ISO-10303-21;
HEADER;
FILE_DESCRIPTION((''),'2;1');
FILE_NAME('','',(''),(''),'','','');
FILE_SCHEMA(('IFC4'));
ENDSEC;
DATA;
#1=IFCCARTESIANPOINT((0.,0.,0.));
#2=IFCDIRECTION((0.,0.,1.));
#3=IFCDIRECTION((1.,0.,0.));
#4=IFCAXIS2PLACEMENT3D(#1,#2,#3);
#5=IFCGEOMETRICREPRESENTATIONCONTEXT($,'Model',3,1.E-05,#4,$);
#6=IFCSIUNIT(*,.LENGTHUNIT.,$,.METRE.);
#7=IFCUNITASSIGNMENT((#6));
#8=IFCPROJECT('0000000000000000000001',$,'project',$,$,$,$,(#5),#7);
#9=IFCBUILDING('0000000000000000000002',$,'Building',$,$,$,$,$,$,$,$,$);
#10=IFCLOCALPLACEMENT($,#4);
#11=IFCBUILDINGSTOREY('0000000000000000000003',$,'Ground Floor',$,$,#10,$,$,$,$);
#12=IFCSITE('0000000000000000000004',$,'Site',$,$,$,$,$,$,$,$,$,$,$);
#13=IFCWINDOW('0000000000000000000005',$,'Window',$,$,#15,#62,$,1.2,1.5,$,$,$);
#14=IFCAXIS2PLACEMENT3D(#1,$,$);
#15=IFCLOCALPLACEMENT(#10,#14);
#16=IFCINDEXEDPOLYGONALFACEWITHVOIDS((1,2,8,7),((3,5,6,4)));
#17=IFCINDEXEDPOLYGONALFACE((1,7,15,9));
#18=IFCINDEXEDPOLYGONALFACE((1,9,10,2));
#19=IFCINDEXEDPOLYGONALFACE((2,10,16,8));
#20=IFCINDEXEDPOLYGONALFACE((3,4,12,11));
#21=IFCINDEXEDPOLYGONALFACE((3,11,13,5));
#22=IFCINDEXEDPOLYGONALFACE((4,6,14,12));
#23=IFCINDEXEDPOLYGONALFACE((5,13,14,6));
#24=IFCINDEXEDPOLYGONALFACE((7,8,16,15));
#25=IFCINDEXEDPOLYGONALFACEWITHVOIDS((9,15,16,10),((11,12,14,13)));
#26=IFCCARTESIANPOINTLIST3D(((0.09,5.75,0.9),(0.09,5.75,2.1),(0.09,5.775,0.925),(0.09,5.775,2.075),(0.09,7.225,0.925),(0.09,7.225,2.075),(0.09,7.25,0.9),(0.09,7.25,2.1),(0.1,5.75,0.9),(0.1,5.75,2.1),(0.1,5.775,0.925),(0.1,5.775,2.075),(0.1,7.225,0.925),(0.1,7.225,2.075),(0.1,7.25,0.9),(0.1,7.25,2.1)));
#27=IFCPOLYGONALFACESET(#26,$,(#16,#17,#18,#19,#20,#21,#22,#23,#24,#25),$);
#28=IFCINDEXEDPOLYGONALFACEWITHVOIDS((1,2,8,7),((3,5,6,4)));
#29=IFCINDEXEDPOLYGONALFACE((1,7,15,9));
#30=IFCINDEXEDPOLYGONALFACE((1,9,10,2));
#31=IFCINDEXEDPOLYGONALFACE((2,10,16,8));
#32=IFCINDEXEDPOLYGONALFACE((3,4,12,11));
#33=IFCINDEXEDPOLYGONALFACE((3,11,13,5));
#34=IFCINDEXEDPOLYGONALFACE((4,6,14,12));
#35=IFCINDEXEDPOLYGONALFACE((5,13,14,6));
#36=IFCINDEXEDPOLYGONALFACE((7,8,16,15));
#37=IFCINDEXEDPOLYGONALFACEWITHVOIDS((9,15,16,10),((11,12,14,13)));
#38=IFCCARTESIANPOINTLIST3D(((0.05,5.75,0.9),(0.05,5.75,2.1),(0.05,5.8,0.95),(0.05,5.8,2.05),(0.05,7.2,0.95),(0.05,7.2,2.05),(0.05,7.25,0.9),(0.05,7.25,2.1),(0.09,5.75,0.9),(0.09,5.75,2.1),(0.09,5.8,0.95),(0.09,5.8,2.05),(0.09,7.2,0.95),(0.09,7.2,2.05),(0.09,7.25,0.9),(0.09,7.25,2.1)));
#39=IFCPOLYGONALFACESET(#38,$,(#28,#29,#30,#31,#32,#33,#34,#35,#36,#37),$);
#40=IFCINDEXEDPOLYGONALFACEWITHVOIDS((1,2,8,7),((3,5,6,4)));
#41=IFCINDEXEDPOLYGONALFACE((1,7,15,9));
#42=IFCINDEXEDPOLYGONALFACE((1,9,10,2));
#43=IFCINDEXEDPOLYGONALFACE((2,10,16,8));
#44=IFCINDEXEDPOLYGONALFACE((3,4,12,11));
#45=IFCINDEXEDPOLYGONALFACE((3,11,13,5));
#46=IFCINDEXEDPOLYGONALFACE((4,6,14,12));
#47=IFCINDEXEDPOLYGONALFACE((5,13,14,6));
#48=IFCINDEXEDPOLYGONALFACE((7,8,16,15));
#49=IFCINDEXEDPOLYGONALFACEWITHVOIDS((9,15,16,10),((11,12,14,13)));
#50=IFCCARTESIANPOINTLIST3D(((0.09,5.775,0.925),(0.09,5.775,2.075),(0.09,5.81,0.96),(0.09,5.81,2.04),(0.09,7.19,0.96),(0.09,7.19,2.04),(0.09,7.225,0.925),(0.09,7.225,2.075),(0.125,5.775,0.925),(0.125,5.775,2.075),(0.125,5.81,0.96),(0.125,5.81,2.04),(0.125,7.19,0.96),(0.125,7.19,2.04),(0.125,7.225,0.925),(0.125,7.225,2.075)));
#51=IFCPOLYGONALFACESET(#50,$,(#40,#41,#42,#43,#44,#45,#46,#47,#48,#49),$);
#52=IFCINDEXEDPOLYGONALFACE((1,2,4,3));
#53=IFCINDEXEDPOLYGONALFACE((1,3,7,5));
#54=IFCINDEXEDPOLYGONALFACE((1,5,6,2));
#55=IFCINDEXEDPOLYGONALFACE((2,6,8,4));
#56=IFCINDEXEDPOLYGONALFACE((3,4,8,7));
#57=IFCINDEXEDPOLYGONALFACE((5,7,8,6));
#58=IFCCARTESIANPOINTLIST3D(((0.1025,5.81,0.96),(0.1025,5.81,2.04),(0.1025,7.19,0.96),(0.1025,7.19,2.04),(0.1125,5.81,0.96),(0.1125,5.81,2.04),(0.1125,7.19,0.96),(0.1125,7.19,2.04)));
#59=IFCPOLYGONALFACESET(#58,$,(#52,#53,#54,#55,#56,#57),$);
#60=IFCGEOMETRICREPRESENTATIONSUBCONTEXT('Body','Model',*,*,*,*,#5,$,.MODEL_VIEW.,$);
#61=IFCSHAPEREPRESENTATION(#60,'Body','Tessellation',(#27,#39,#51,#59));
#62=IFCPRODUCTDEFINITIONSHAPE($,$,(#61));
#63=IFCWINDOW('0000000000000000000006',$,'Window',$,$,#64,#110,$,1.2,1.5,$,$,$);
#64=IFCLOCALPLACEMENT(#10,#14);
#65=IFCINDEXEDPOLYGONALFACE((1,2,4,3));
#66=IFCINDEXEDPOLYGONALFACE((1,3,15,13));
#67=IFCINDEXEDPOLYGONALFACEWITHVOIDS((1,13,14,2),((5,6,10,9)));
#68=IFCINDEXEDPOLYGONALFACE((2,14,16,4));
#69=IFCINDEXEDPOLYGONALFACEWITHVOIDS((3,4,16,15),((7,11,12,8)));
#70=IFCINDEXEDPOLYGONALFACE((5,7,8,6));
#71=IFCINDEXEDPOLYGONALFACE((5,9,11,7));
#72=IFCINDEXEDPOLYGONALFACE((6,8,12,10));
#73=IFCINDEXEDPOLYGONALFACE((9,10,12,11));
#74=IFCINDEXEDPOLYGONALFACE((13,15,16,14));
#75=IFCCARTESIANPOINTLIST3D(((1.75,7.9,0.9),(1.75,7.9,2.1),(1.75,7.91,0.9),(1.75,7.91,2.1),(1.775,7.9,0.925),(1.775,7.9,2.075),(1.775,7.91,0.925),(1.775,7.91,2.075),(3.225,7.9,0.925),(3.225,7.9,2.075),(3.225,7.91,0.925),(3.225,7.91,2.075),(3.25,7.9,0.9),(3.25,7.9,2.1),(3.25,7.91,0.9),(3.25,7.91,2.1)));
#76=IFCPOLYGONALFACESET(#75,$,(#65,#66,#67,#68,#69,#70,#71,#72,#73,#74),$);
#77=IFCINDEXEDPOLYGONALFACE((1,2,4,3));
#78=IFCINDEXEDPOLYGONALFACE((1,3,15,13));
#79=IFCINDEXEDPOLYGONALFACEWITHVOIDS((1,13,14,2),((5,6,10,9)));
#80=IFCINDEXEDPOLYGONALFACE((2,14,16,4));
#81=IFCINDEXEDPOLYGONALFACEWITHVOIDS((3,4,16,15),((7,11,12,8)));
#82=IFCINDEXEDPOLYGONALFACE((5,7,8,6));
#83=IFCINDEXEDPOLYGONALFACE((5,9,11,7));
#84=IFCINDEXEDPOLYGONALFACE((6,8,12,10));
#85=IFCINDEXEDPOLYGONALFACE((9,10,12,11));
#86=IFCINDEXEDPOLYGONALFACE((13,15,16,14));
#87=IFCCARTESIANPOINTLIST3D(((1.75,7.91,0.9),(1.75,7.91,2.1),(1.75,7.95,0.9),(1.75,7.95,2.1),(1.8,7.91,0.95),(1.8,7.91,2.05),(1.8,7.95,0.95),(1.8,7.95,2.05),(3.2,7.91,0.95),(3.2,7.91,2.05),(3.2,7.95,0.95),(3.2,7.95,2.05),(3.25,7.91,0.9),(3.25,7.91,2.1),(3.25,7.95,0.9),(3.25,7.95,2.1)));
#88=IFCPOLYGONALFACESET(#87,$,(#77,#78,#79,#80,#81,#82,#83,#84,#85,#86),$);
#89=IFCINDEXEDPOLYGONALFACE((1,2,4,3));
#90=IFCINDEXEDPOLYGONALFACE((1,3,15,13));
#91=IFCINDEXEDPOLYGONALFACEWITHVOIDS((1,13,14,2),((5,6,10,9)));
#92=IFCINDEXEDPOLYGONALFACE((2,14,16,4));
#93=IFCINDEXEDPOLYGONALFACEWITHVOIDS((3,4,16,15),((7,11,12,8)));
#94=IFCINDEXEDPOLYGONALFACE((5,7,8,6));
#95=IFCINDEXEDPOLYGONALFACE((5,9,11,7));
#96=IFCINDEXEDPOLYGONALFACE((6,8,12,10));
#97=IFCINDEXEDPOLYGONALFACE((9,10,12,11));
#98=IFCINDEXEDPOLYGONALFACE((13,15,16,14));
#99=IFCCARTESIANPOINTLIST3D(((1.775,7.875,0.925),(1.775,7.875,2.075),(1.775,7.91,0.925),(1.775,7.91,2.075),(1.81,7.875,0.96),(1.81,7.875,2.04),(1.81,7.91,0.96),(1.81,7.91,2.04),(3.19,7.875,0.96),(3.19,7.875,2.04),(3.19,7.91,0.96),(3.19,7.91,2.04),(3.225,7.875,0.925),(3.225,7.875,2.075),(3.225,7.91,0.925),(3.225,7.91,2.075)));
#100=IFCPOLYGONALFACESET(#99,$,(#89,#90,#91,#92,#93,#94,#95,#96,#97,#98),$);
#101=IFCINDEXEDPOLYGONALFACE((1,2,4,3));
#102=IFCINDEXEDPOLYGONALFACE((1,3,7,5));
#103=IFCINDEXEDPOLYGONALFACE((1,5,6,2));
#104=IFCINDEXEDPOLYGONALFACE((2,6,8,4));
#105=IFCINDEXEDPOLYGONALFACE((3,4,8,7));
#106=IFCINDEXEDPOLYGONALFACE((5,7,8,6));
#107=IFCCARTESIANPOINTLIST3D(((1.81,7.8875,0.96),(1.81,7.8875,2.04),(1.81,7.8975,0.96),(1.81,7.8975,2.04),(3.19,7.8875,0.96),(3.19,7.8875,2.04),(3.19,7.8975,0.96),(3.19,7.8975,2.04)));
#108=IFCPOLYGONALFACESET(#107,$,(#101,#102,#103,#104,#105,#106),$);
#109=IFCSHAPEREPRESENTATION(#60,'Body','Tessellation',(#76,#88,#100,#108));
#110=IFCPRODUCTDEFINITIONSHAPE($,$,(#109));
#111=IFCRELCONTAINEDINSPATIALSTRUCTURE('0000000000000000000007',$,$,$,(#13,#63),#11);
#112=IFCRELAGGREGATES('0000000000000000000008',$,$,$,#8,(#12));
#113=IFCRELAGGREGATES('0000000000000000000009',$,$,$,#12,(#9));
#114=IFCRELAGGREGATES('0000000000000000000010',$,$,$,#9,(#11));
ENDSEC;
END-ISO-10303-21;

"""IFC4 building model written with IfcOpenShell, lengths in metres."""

from ifc_helpers import new_model, si_unit, frame, origin_with_axes, place, context, subcontext, project, spatial, line, indexed_curve, outline, extrude, element, save


model = new_model("IFC4")

# Units and contexts
model_context = context("Model", 3, precision=1e-05, world=origin_with_axes())
body_context = subcontext(model_context, "Body", "Model", "MODEL_VIEW")
ifc_project = project(units=[si_unit("LENGTHUNIT", "METRE")], contexts=[model_context])

# Site, building, storey
site = spatial("IfcSite", under=ifc_project, Name="Site")
building = spatial("IfcBuilding", under=site, Name="Building")
storey_placement = place(None, origin_with_axes())
storey = spatial("IfcBuildingStorey", under=building, at=storey_placement, Name="Ground Floor")

# Windows
for number, where, z_axis, x_axis, name in (
    (1, (0.0, 7.25, 0.9), (0.0, 0.0, 1.0), (0.0, -1.0, 0.0), "Window"),
    (2, (3.25, 8.0, 0.9), (0.0, 0.0, 1.0), (-1.0, 0.0, 0.0), "Window"),
):
    element("IfcWindow", number, at=place(storey_placement, frame(where, z_axis=z_axis, x_axis=x_axis)), inside=storey, Name=name, OverallHeight=1.2, OverallWidth=1.5, context=body_context, shape_type="SweptSolid", body=[
        extrude(outline(indexed_curve([(0.0, 0.0), (1.5, 0.0), (1.5, 1.2), (0.0, 1.2)], segments=[line(1, 2, 3, 4, 1)]), holes=[indexed_curve([(0.025, 0.025), (1.475, 0.025), (1.475, 1.175), (0.025, 1.175)], segments=[line(1, 2, 3, 4, 1)])]), frame((0.0, 0.09, 0.0), z_axis=(0.0, -1.0, 0.0), x_axis=(1.0, 0.0, 0.0)), (0.0, 0.0, -1.0), 0.01),
        extrude(outline(indexed_curve([(0.0, 0.0), (1.5, 0.0), (1.5, 1.2), (0.0, 1.2)], segments=[line(1, 2, 3, 4, 1)]), holes=[indexed_curve([(0.05, 0.05), (1.45, 0.05), (1.45, 1.15), (0.05, 1.15)], segments=[line(1, 2, 3, 4, 1)])]), frame((0.0, 0.05, 0.0), z_axis=(0.0, -1.0, 0.0), x_axis=(1.0, 0.0, 0.0)), (0.0, 0.0, -1.0), 0.04),
        extrude(outline(indexed_curve([(0.0, 0.0), (1.45, 0.0), (1.45, 1.15), (0.0, 1.15)], segments=[line(1, 2, 3, 4, 1)]), holes=[indexed_curve([(0.035, 0.035), (1.415, 0.035), (1.415, 1.115), (0.035, 1.115)], segments=[line(1, 2, 3, 4, 1)])]), frame((0.025, 0.09, 0.025), z_axis=(0.0, -1.0, 0.0), x_axis=(1.0, 0.0, 0.0)), (0.0, 0.0, -1.0), 0.035),
        extrude(outline(indexed_curve([(0.035, 0.035), (1.415, 0.035), (1.415, 1.115), (0.035, 1.115)], segments=[line(1, 2, 3, 4, 1)])), frame((0.025, 0.1025, 0.025), z_axis=(0.0, -1.0, 0.0), x_axis=(1.0, 0.0, 0.0)), (0.0, 0.0, -1.0), 0.01),
    ])

save(model, "model.ifc")
